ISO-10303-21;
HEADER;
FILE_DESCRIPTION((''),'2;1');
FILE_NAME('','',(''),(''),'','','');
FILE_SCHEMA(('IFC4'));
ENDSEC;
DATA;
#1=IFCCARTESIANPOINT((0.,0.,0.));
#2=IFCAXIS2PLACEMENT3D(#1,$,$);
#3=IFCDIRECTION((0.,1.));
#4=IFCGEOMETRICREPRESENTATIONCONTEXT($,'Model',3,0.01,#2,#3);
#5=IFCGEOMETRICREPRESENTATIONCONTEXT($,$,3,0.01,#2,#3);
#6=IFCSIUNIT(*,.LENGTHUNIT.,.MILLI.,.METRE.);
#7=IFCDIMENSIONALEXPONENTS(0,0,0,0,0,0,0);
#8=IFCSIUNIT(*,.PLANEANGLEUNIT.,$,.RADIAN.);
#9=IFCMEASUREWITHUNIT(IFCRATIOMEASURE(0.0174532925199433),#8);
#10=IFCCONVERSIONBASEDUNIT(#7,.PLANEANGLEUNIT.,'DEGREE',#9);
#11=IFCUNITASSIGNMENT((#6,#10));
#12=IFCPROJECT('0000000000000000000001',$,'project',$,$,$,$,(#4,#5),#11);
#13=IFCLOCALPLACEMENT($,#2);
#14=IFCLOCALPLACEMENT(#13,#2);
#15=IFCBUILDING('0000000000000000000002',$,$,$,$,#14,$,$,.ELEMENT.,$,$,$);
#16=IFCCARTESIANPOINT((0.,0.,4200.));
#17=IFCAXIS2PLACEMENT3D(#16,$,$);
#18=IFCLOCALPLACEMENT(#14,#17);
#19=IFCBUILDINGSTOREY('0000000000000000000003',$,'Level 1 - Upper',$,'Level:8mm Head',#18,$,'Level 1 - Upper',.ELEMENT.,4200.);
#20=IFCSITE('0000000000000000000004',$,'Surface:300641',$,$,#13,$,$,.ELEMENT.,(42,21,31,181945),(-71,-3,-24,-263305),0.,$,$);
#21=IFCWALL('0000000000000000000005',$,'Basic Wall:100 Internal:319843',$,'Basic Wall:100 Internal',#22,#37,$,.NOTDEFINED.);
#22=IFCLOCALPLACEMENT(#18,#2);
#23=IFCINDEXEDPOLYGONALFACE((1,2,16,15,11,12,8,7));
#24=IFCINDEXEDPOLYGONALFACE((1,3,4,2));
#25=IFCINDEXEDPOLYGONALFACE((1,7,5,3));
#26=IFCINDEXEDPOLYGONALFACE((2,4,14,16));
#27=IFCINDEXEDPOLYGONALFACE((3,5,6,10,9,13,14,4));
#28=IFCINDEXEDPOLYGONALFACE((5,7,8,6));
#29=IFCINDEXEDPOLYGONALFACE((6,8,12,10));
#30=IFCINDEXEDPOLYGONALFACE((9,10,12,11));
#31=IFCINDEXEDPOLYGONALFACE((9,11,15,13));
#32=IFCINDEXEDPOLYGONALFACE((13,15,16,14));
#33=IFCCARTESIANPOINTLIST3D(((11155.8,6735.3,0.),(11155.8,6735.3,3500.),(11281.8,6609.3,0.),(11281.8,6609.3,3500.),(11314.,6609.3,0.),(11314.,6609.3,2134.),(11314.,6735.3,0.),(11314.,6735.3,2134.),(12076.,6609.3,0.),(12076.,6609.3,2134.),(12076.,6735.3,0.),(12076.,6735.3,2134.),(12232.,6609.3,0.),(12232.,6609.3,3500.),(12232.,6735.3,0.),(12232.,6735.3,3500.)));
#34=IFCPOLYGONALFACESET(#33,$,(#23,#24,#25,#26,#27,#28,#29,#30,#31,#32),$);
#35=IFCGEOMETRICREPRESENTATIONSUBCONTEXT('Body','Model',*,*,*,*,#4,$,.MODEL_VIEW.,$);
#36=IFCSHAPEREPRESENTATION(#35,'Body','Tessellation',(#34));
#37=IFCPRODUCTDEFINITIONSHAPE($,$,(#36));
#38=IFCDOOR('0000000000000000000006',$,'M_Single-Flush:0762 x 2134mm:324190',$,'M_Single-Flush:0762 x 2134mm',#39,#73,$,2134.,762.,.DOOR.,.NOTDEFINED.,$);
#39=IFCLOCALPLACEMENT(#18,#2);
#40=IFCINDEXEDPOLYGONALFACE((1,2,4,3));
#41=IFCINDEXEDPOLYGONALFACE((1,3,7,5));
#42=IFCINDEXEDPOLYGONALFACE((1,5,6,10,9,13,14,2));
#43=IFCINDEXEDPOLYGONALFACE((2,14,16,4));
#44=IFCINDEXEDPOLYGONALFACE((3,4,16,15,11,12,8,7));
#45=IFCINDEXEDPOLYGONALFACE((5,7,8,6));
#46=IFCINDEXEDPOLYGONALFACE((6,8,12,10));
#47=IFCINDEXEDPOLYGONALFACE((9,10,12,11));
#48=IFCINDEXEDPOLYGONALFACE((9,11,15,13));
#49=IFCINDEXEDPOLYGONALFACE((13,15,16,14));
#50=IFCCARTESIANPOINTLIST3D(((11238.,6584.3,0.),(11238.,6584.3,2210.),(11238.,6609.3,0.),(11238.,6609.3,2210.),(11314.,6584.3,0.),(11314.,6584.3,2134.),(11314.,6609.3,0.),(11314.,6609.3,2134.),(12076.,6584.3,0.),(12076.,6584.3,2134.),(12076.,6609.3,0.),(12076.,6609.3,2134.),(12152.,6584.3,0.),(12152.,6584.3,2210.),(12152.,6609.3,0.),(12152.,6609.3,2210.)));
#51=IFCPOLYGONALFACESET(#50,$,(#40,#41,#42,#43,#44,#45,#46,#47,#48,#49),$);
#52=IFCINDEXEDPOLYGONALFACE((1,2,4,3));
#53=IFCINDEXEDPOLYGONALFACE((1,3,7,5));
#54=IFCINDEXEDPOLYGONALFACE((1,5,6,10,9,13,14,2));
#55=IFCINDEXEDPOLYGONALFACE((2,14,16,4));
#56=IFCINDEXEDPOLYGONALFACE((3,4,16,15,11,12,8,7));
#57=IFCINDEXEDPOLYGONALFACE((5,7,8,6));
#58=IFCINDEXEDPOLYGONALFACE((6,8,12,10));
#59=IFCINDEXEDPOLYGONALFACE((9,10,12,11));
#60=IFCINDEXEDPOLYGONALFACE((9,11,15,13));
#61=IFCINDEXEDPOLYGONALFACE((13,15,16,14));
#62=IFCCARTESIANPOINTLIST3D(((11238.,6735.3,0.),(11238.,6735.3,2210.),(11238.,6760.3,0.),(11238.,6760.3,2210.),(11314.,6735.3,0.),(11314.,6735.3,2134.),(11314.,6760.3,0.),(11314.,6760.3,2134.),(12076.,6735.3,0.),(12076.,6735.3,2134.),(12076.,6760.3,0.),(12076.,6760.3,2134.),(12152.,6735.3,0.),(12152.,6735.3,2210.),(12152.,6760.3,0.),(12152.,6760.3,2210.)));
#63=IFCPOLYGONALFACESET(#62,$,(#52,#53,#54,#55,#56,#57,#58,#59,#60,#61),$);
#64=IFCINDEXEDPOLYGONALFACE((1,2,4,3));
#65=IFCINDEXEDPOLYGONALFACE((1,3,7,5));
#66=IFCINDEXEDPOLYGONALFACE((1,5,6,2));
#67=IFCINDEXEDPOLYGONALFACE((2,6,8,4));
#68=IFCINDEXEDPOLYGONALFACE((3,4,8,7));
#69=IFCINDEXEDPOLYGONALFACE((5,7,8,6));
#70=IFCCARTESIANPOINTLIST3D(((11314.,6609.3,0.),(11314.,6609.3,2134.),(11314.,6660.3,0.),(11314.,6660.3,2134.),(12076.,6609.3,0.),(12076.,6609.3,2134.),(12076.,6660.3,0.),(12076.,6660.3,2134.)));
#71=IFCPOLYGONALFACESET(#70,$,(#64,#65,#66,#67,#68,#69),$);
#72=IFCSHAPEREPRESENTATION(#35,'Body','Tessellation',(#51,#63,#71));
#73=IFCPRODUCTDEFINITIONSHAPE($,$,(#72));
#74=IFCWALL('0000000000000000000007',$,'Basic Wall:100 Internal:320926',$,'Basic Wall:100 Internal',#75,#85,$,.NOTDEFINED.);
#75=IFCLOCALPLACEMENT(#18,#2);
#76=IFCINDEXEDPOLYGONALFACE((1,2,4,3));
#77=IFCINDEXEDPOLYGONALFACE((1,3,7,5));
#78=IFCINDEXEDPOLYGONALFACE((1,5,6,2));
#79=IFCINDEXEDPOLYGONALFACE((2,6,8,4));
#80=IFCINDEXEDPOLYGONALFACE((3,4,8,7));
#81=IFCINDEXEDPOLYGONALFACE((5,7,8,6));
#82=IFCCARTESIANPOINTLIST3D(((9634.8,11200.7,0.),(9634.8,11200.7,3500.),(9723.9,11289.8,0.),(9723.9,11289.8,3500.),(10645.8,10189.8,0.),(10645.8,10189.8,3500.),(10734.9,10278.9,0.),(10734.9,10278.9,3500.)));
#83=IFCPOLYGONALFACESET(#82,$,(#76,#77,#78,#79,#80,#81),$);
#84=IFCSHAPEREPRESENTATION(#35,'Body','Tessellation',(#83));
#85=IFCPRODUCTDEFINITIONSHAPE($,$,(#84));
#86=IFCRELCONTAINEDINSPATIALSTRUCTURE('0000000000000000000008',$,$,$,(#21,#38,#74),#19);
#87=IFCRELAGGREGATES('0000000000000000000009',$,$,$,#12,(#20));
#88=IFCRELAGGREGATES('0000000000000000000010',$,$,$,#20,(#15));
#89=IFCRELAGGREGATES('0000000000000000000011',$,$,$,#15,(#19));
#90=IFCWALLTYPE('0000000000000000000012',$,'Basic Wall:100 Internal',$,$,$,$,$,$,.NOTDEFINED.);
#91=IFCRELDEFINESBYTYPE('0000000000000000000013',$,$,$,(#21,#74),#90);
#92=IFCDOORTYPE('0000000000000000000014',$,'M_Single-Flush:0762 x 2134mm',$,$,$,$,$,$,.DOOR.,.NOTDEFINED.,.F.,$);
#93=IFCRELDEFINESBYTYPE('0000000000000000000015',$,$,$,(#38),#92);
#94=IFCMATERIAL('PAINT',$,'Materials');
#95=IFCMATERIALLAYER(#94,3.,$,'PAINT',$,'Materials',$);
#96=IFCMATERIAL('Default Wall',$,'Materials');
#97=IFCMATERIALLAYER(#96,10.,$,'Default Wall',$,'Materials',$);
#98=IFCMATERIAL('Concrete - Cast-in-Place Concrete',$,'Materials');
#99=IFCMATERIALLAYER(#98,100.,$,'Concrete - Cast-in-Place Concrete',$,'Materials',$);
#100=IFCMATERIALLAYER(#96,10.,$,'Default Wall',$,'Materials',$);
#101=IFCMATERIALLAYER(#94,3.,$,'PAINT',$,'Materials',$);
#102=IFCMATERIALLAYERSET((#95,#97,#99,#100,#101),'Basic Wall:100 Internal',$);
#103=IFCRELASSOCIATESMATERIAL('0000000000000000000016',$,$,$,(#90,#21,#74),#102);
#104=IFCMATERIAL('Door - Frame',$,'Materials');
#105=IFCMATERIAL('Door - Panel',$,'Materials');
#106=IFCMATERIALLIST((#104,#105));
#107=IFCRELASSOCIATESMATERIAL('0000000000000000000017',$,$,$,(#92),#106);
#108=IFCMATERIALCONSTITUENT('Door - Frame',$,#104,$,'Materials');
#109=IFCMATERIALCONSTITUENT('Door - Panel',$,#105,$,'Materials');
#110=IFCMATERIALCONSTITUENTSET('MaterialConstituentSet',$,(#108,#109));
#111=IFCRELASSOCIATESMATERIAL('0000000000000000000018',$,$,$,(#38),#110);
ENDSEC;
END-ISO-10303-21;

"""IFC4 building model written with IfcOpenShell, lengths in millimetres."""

from ifc_helpers import new_model, entity, si_unit, converted_unit, direction, frame, frame_2d, origin, place, context, subcontext, project, spatial, polyline, rectangle, outline, extrude, clip, halfspace, source, transform, mapped, material, material_list, layer, layer_set, layer_usage, constituent, constituent_set, type_object, type_shapes, element, fill, save


model = new_model("IFC4")

# Units and contexts
model_context = context("Model", 3, precision=0.01, world=origin(), true_north=direction((0.0, 1.0)))
context_of_model = context(None, 3, precision=0.01, world=origin(), true_north=direction((0.0, 1.0)))
body_context = subcontext(model_context, "Body", "Model", "MODEL_VIEW")
ifc_project = project(units=[si_unit("LENGTHUNIT", "METRE", prefix="MILLI"), converted_unit("PLANEANGLEUNIT", "DEGREE", entity("IfcRatioMeasure", 0.0174532925199433), si_unit("PLANEANGLEUNIT", "RADIAN"), dimensions=[0, 0, 0, 0, 0, 0, 0])], contexts=[model_context, context_of_model])

# Site, building, storey
site_placement = place(None, origin())
site = spatial("IfcSite", under=ifc_project, at=site_placement, Name="Surface:300641", CompositionType="ELEMENT", RefLatitude=(42, 21, 31, 181945), RefLongitude=(-71, -3, -24, -263305), RefElevation=0.0)
building_placement = place(site_placement, origin())
building = spatial("IfcBuilding", under=site, at=building_placement, CompositionType="ELEMENT")
storey_placement = place(building_placement, frame((0.0, 0.0, 4200.0)))
storey = spatial("IfcBuildingStorey", under=building, at=storey_placement, Name="Level 1 - Upper", ObjectType="Level:8mm Head", LongName="Level 1 - Upper", CompositionType="ELEMENT", Elevation=4200.0)

# Shared definitions
ifc_material_1 = material(Name="PAINT", Category="Materials")
ifc_material_2 = material(Name="Concrete - Cast-in-Place Concrete", Category="Materials")
ifc_material_3 = material(Name="Default Wall", Category="Materials")

# Shared definitions
ifc_layer_1 = layer(ifc_material_1, 3.0, Name="PAINT", Category="Materials")
ifc_layer_2 = layer(ifc_material_3, 10.0, Name="Default Wall", Category="Materials")
ifc_layer_3 = layer(ifc_material_2, 100.0, Name="Concrete - Cast-in-Place Concrete", Category="Materials")
ifc_layer_4 = layer(ifc_material_3, 10.0, Name="Default Wall", Category="Materials")
ifc_layer_5 = layer(ifc_material_1, 3.0, Name="PAINT", Category="Materials")
ifc_layer_set_1 = layer_set([ifc_layer_1, ifc_layer_2, ifc_layer_3, ifc_layer_4, ifc_layer_5], Name="Basic Wall:100 Internal")
wall_type_1 = type_object("IfcWallType", Name="Basic Wall:100 Internal", PredefinedType="NOTDEFINED", material=ifc_layer_set_1)

# Shared definitions
ifc_material_4 = material(Name="Door - Frame", Category="Materials")
ifc_material_5 = material(Name="Door - Panel", Category="Materials")
ifc_material_list = material_list([ifc_material_4, ifc_material_5])
door_type = type_object("IfcDoorType", Name="M_Single-Flush:0762 x 2134mm", OperationType="NOTDEFINED", ParameterTakesPrecedence=False, PredefinedType="DOOR", material=ifc_material_list)
shared_shape_1 = source(origin(), body_context, "Body", "SweptSolid", [
    extrude(outline(polyline([(-457.0, -1124.0), (457.0, -1124.0), (457.0, 1086.0), (381.0, 1086.0), (381.0, -1048.0), (-381.0, -1048.0), (-381.0, 1086.0), (-457.0, 1086.0), (-457.0, -1124.0)])), frame((381.0, 151.0, 1086.0), z_axis=(0.0, -1.0, 0.0), x_axis=(-1.0, 0.0, 0.0)), (0.0, 0.0, 1.0), 25.0),
    extrude(outline(polyline([(-1124.0, -457.0), (1086.0, -457.0), (1086.0, -381.0), (-1048.0, -381.0), (-1048.0, 381.0), (1086.0, 381.0), (1086.0, 457.0), (-1124.0, 457.0), (-1124.0, -457.0)])), frame((381.0, 0.0, 1086.0), z_axis=(0.0, -1.0, 0.0), x_axis=(0.0, 0.0, -1.0)), (0.0, 0.0, 1.0), 25.0),
    extrude(rectangle(XDim=762.0, YDim=51.0, at=frame_2d((0.0, 0.0), x_axis=(1.0, 0.0))), frame((381.0, 100.5, 0.0)), (0.0, 0.0, 1.0), 2134.0),
])
type_shapes(door_type, [shared_shape_1])

# Wall, opening, door
ifc_layer_usage_1 = layer_usage(ifc_layer_set_1, "AXIS2", "NEGATIVE", 63.0)
wall_1_placement = place(storey_placement, frame((11155.8, 6672.3, 0.0)))
wall_1 = element("IfcWall", 1, at=wall_1_placement, inside=storey, type_object=wall_type_1, material=ifc_layer_usage_1, Name="Basic Wall:100 Internal:319843", ObjectType="Basic Wall:100 Internal", PredefinedType="NOTDEFINED", context=body_context, shape_type="Clipping", body=[
    clip(extrude(outline(polyline([(126.0, -63.0), (1076.2, -63.0), (1076.2, 63.0), (0.0, 63.0), (126.0, -63.0)])), origin(), (0.0, 0.0, 1.0), 3500.0), halfspace(origin(), True)),
])
opening_1_placement = place(wall_1_placement, frame((920.2, 63.0, 0.0)))
opening_1 = element("IfcOpeningElement", 2, at=opening_1_placement, cuts=wall_1, ObjectType="Opening", PredefinedType="OPENING", context=body_context, shape_type="SweptSolid", body=[
    extrude(rectangle(XDim=762.0, YDim=2134.0, at=frame_2d((1067.0, 381.0), x_axis=(0.0, -1.0))), frame((0.0, 0.0, 0.0), z_axis=(0.0, -1.0, 0.0), x_axis=(0.0, 0.0, 1.0)), (0.0, 0.0, 1.0), 126.0),
])
ifc_constituent_1 = constituent(ifc_material_4, Name="Door - Frame", Category="Materials")
ifc_constituent_2 = constituent(ifc_material_5, Name="Door - Panel", Category="Materials")
ifc_constituent_set_1 = constituent_set(constituents=[ifc_constituent_1, ifc_constituent_2], Name="MaterialConstituentSet")
door_1_placement = place(opening_1_placement, frame((0.0, 0.0, 0.0), z_axis=(0.0, 0.0, 1.0), x_axis=(-1.0, 0.0, 0.0)))
door_1 = element("IfcDoor", 3, at=door_1_placement, inside=storey, type_object=door_type, material=ifc_constituent_set_1, Name="M_Single-Flush:0762 x 2134mm:324190", ObjectType="M_Single-Flush:0762 x 2134mm", OperationType="NOTDEFINED", OverallHeight=2134.0, OverallWidth=762.0, PredefinedType="DOOR", context=body_context, shape_type="MappedRepresentation", body=[
    mapped(shared_shape_1, transform((0.0, 0.0, 0.0), scale=1.0)),
])
fill(opening_1, door_1)

# Wall
ifc_layer_usage_2 = layer_usage(ifc_layer_set_1, "AXIS2", "NEGATIVE", 63.0)
wall_2_placement = place(storey_placement, frame((10690.3, 10234.3, 0.0), z_axis=(0.0, 0.0, 1.0), x_axis=(-0.707107, 0.707107, 0.0)))
element("IfcWall", 4, at=wall_2_placement, inside=storey, type_object=wall_type_1, material=ifc_layer_usage_2, Name="Basic Wall:100 Internal:320926", ObjectType="Basic Wall:100 Internal", PredefinedType="NOTDEFINED", context=body_context, shape_type="Clipping", body=[
    clip(extrude(rectangle(XDim=1429.7, YDim=126.0, at=frame_2d((714.9, 0.0), x_axis=(-1.0, 0.0))), origin(), (0.0, 0.0, 1.0), 3500.0), halfspace(origin(), True)),
])

save(model, "model.ifc")
